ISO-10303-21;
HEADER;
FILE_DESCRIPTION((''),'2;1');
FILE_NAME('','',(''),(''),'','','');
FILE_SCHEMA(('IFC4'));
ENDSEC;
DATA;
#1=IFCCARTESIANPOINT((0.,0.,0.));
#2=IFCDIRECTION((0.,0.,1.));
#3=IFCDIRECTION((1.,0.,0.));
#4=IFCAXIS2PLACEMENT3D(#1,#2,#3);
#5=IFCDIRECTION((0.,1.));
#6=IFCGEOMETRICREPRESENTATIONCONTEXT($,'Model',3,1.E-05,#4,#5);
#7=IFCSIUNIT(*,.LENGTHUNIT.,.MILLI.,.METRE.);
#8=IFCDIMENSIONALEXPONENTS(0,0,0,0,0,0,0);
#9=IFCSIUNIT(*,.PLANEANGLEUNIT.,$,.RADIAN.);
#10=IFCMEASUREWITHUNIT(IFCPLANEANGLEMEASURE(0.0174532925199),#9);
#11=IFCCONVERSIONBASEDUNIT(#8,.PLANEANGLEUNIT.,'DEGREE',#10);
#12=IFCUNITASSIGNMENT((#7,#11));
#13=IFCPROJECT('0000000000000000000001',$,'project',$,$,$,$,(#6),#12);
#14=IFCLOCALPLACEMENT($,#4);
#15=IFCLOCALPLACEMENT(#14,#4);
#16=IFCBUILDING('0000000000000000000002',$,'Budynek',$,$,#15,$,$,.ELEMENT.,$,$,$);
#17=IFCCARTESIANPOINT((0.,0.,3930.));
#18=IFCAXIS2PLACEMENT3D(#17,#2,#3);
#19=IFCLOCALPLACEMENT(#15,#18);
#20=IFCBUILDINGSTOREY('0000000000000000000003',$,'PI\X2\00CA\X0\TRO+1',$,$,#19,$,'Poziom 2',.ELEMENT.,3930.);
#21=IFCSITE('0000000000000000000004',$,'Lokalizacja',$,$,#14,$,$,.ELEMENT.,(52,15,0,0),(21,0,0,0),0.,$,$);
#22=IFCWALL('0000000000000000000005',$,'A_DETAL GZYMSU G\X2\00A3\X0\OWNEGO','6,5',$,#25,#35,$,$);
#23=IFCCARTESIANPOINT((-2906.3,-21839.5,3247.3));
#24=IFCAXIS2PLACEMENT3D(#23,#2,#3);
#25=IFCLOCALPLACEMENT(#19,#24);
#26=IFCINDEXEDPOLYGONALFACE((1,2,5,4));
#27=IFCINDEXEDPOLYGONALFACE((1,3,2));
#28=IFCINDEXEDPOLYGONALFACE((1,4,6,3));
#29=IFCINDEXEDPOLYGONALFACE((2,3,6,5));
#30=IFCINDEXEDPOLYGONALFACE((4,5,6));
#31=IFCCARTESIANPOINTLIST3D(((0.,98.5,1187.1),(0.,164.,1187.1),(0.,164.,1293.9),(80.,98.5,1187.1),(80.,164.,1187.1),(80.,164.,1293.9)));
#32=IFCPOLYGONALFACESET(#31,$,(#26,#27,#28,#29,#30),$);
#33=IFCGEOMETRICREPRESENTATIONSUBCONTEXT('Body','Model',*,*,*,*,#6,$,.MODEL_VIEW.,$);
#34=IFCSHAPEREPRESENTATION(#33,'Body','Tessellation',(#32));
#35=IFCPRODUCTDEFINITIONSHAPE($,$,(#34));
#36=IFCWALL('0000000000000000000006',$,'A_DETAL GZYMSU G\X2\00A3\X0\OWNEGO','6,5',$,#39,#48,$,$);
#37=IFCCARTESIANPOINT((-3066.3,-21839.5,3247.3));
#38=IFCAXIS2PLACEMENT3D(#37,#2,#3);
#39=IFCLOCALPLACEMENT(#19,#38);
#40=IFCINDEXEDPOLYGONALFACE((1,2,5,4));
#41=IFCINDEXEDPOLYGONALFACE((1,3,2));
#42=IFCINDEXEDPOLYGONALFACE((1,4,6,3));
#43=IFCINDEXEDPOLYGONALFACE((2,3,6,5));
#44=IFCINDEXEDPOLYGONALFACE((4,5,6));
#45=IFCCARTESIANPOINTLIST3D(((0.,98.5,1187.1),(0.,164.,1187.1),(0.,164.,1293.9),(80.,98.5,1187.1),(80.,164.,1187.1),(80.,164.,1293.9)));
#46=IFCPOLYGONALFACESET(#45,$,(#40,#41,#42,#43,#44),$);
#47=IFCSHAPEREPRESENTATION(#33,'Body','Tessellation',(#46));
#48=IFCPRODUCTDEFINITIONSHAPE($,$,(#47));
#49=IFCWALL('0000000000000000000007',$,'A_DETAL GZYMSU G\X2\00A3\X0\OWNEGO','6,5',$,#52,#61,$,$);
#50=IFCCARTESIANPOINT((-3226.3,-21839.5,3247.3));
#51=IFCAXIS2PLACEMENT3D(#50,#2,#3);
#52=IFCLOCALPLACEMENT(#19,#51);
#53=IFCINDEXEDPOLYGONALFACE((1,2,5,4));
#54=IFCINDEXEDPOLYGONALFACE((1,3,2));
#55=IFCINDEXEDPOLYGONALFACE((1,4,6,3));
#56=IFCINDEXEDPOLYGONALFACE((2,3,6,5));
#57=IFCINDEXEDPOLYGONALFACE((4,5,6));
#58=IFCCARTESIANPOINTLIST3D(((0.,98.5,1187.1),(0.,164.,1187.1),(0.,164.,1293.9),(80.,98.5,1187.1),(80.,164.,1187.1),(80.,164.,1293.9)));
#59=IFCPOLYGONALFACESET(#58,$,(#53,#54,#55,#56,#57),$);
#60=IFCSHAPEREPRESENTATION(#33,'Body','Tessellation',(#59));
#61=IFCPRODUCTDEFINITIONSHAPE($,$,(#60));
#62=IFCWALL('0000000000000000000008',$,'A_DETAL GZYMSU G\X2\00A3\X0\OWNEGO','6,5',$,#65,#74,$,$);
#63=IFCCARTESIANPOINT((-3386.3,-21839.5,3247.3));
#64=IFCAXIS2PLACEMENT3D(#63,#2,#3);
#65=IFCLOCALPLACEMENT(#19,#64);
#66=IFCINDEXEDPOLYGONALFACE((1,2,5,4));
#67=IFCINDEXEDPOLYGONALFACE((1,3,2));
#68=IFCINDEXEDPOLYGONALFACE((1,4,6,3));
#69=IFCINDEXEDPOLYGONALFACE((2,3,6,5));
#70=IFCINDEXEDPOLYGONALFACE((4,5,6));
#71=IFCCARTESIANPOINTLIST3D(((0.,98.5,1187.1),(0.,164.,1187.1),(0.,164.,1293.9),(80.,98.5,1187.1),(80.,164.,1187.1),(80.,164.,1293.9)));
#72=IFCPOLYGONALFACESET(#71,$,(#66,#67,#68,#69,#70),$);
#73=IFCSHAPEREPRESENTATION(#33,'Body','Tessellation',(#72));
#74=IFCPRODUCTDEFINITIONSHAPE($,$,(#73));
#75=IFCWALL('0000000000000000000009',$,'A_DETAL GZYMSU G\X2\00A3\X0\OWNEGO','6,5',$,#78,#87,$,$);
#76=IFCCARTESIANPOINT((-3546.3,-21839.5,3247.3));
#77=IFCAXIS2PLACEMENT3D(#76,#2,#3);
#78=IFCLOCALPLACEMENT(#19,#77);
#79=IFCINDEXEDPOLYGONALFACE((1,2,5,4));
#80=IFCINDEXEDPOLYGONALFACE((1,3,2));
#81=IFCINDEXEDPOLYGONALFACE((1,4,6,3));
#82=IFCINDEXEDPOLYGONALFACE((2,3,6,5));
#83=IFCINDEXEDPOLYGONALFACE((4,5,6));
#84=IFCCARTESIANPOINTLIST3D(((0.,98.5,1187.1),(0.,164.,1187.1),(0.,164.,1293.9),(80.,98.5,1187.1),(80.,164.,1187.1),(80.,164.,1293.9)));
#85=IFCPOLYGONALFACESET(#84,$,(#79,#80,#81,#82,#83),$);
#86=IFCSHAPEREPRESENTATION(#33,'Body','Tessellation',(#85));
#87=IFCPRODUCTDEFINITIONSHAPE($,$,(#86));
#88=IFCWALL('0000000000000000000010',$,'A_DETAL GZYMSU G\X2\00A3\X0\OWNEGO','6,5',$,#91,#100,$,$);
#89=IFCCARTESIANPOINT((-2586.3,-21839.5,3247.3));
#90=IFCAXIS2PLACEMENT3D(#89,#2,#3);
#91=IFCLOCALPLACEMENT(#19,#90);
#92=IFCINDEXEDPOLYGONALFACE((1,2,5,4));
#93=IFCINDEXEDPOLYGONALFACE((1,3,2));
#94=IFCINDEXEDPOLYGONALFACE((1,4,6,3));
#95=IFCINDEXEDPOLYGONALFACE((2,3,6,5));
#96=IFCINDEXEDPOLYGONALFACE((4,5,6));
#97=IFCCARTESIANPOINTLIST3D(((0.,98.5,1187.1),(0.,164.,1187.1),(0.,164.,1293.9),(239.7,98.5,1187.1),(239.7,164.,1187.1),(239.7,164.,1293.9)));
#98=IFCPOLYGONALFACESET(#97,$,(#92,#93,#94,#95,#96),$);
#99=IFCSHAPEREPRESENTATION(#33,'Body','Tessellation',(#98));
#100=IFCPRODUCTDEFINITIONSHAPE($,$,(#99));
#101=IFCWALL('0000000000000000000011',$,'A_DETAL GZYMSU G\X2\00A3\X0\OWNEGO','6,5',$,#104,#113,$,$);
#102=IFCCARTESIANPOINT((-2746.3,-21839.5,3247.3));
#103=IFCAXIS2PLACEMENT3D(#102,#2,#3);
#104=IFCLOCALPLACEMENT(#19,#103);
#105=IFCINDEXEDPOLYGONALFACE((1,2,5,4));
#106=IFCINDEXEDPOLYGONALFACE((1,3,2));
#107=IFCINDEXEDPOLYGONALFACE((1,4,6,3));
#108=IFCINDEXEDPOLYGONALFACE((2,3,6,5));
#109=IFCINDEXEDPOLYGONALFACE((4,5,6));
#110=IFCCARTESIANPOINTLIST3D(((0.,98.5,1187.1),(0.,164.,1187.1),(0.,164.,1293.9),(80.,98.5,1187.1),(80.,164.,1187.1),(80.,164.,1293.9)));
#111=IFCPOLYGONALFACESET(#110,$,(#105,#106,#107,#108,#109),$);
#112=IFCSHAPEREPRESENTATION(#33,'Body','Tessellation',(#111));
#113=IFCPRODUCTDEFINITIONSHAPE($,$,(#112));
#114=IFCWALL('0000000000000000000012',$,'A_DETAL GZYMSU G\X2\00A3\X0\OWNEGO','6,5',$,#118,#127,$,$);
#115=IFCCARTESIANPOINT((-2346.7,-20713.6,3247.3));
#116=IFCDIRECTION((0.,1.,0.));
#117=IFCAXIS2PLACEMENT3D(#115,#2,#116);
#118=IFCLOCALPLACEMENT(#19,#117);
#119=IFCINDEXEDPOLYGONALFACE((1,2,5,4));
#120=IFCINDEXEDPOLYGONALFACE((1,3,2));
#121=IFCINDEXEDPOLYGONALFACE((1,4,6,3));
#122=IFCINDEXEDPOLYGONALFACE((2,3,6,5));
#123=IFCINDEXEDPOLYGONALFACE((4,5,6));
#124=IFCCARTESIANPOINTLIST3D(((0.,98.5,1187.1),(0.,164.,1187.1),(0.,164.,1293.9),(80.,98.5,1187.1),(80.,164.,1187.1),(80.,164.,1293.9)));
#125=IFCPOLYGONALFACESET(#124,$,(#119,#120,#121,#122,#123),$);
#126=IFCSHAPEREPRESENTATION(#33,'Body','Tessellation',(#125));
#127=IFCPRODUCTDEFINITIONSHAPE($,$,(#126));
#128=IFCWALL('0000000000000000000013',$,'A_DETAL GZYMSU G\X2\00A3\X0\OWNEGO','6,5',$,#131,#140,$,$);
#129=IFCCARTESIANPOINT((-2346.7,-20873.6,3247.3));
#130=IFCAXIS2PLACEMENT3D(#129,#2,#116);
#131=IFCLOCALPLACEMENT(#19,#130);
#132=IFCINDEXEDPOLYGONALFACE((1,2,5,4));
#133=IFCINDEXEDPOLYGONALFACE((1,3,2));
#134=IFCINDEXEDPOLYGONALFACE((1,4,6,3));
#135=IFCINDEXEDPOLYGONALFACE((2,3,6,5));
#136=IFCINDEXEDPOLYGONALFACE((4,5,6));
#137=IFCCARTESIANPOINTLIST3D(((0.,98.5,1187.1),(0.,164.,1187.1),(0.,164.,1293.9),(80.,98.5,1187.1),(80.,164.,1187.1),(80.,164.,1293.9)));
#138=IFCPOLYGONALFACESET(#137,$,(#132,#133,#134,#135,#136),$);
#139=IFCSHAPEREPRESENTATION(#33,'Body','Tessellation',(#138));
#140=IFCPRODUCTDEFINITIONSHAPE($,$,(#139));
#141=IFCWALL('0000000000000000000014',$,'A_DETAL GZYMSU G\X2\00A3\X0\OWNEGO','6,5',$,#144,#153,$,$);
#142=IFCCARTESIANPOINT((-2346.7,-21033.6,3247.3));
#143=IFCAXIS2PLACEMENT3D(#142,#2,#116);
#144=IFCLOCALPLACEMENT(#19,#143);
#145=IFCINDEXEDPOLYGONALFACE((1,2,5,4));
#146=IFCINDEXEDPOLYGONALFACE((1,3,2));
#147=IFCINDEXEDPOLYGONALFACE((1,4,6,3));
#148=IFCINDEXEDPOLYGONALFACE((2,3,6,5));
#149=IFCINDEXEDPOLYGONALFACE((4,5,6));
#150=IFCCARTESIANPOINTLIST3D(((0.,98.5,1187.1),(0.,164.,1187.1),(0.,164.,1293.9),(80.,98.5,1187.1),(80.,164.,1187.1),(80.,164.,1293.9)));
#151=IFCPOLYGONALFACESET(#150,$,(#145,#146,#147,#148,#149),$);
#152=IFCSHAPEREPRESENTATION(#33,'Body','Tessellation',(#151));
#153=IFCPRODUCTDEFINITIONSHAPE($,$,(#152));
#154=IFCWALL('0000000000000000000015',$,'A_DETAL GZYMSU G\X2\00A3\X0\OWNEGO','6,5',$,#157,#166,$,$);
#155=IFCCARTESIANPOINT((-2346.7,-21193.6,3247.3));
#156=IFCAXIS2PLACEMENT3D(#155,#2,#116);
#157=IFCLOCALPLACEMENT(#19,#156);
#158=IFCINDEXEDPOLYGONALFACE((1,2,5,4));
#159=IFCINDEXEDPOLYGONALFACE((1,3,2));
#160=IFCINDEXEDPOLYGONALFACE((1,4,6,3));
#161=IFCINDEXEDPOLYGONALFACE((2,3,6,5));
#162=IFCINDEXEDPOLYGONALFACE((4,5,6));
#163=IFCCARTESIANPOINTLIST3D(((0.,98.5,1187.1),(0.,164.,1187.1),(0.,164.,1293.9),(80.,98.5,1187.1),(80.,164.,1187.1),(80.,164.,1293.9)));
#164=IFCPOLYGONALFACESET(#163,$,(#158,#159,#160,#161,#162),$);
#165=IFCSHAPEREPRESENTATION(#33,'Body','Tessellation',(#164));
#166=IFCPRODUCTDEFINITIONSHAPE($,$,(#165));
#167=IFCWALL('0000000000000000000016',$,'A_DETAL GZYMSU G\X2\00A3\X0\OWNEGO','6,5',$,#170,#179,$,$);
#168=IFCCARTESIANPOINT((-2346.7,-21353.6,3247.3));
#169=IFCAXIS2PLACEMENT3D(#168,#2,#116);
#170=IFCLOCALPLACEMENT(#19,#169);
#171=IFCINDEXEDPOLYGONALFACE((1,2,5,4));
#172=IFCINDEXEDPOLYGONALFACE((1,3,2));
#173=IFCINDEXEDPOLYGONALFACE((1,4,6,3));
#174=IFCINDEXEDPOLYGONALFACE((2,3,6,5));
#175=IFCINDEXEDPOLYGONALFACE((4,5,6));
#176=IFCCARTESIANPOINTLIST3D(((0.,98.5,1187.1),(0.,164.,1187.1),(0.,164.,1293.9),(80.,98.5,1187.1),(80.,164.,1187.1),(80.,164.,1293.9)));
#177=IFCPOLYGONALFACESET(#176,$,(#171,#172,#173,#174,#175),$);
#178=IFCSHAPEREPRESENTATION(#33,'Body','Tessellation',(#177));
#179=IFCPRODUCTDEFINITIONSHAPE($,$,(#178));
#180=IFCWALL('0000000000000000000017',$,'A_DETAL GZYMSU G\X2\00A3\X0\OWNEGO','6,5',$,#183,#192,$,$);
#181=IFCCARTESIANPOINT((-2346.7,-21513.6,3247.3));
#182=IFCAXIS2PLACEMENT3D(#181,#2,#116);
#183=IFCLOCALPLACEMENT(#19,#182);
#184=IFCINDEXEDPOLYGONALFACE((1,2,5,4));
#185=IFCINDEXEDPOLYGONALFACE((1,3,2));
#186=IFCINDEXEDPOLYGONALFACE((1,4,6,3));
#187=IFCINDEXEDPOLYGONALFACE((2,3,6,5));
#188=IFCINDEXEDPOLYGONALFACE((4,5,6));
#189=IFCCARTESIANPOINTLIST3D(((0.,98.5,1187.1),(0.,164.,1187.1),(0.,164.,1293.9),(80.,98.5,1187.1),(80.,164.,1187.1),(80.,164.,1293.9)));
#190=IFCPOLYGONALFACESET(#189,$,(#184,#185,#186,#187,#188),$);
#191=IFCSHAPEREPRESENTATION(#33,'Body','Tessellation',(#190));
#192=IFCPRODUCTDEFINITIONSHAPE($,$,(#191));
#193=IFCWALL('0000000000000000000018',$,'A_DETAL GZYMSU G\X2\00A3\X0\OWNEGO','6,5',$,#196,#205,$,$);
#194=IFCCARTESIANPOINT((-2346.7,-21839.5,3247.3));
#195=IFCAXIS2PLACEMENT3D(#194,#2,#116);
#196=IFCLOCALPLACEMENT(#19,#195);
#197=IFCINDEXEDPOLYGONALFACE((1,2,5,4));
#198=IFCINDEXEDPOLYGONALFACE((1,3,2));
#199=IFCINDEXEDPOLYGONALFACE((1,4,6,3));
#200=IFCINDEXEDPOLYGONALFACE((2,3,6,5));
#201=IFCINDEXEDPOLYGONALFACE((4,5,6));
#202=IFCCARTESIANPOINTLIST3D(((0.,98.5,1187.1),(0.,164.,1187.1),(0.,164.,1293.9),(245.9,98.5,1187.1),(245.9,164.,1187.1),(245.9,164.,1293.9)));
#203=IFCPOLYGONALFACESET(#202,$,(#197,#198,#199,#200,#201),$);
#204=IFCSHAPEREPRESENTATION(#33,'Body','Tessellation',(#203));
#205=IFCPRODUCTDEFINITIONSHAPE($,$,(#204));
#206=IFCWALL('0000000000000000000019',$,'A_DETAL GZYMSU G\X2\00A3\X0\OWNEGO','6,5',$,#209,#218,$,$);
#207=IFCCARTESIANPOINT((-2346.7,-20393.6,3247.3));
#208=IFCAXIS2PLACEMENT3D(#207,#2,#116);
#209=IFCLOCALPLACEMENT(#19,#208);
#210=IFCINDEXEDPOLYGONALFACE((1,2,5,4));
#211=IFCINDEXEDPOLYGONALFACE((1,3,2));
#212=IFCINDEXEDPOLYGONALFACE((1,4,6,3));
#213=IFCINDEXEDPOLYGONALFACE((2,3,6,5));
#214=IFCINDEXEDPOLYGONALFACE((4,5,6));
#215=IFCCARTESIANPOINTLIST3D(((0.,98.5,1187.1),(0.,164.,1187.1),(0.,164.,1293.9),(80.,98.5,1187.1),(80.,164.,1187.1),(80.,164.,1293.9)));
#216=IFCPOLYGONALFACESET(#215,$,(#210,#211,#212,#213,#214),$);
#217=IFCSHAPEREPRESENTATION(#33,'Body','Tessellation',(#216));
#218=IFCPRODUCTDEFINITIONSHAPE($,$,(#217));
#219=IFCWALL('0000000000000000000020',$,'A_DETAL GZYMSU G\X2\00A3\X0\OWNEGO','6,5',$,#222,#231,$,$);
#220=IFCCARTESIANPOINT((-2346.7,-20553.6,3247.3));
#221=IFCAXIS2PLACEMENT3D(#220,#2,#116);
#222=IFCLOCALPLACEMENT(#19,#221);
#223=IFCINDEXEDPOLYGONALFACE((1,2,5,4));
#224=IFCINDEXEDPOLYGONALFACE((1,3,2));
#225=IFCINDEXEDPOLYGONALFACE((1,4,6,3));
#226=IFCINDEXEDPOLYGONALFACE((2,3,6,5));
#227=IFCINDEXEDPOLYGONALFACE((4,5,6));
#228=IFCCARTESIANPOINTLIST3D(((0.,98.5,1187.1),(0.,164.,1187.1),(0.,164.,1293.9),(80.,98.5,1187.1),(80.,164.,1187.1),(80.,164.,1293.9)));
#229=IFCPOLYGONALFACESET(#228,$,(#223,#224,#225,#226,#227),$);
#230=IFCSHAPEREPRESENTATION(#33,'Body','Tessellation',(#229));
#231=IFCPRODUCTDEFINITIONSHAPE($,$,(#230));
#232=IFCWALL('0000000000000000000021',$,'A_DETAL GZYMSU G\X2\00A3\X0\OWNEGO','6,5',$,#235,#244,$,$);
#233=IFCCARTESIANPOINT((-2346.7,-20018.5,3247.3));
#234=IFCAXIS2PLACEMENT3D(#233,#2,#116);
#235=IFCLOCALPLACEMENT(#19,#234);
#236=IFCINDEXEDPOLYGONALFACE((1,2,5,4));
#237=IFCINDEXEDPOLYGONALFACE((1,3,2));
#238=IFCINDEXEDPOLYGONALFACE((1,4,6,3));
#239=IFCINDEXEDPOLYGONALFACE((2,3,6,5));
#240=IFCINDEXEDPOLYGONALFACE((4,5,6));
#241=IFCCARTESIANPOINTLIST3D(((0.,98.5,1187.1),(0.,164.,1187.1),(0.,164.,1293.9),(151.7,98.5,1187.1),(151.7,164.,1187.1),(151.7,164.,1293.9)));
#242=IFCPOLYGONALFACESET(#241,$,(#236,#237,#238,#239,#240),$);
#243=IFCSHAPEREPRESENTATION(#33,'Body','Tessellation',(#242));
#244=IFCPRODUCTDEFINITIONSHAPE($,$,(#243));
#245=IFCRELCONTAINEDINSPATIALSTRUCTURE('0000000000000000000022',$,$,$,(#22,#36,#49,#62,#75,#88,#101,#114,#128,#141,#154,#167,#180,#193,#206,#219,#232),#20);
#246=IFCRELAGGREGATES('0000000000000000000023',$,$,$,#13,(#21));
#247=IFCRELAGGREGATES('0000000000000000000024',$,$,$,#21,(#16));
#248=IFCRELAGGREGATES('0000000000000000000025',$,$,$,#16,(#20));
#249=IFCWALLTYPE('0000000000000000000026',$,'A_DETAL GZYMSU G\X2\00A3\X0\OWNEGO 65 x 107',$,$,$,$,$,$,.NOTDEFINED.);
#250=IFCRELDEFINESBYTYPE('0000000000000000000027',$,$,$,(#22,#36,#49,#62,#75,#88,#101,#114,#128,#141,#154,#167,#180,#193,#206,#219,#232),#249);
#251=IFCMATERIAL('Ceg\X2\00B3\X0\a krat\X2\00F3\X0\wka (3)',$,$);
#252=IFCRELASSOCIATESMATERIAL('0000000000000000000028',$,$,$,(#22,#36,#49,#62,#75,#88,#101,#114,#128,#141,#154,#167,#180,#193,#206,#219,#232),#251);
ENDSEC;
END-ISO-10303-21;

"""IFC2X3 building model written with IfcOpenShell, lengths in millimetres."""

from ifc_helpers import new_model, entity, si_unit, converted_unit, direction, frame, origin_with_axes, place, context, subcontext, project, spatial, polyline, outline, extrude, material, type_object, element, save


model = new_model("IFC2X3")

# Units and contexts
model_context = context("Model", 3, precision=1e-05, world=origin_with_axes(), true_north=direction((0.0, 1.0)))
body_context = subcontext(model_context, "Body", "Model", "MODEL_VIEW")
ifc_project = project(units=[si_unit("LENGTHUNIT", "METRE", prefix="MILLI"), converted_unit("PLANEANGLEUNIT", "DEGREE", entity("IfcPlaneAngleMeasure", 0.0174532925199), si_unit("PLANEANGLEUNIT", "RADIAN"), dimensions=[0, 0, 0, 0, 0, 0, 0])], contexts=[model_context])

# Site, building, storey
site_placement = place(None, origin_with_axes())
site = spatial("IfcSite", under=ifc_project, at=site_placement, Name="Lokalizacja", CompositionType="ELEMENT", RefLatitude=(52, 15, 0, 0), RefLongitude=(21, 0, 0, 0), RefElevation=0.0)
building_placement = place(site_placement, origin_with_axes())
building = spatial("IfcBuilding", under=site, at=building_placement, Name="Budynek", CompositionType="ELEMENT")
storey_placement = place(building_placement, frame((0.0, 0.0, 3930.0), z_axis=(0.0, 0.0, 1.0), x_axis=(1.0, 0.0, 0.0)))
storey = spatial("IfcBuildingStorey", under=building, at=storey_placement, Name="PIÊTRO+1", LongName="Poziom 2", CompositionType="ELEMENT", Elevation=3930.0)

# Shared definitions
ifc_material_1 = material(Name="Ceg³a kratówka (3)")

# Walls
wall_type_1 = type_object("IfcWallType", Name="A_DETAL GZYMSU G£OWNEGO 65 x 107", PredefinedType="NOTDEFINED")
for number, where, z_axis, x_axis, name in (
    (1, (-2906.3, -21839.5, 3247.3), (0.0, 0.0, 1.0), (1.0, 0.0, 0.0), "A_DETAL GZYMSU G£OWNEGO"),
    (2, (-3066.3, -21839.5, 3247.3), (0.0, 0.0, 1.0), (1.0, 0.0, 0.0), "A_DETAL GZYMSU G£OWNEGO"),
    (3, (-3226.3, -21839.5, 3247.3), (0.0, 0.0, 1.0), (1.0, 0.0, 0.0), "A_DETAL GZYMSU G£OWNEGO"),
    (4, (-3386.3, -21839.5, 3247.3), (0.0, 0.0, 1.0), (1.0, 0.0, 0.0), "A_DETAL GZYMSU G£OWNEGO"),
    (5, (-3546.3, -21839.5, 3247.3), (0.0, 0.0, 1.0), (1.0, 0.0, 0.0), "A_DETAL GZYMSU G£OWNEGO"),
):
    element("IfcWall", number, at=place(storey_placement, frame(where, z_axis=z_axis, x_axis=x_axis)), inside=storey, type_object=wall_type_1, material=ifc_material_1, Name=name, Description="6,5", context=body_context, shape_type="SweptSolid", body=[
        extrude(outline(polyline([(-164.0, 1293.9), (-164.0, 1187.1), (-98.5, 1187.1), (-164.0, 1293.9)])), frame((0.0, 0.0, 0.0), z_axis=(-1.0, 0.0, 0.0), x_axis=(0.0, -1.0, 0.0)), (0.0, 0.0, -1.0), 80.0),
    ])
wall_1_placement = place(storey_placement, frame((-2586.3, -21839.5, 3247.3), z_axis=(0.0, 0.0, 1.0), x_axis=(1.0, 0.0, 0.0)))
element("IfcWall", 6, at=wall_1_placement, inside=storey, type_object=wall_type_1, material=ifc_material_1, Name="A_DETAL GZYMSU G£OWNEGO", Description="6,5", context=body_context, shape_type="SweptSolid", body=[
    extrude(outline(polyline([(-164.0, 1293.9), (-164.0, 1187.1), (-98.5, 1187.1), (-164.0, 1293.9)])), frame((0.0, 0.0, 0.0), z_axis=(-1.0, 0.0, 0.0), x_axis=(0.0, -1.0, 0.0)), (0.0, 0.0, -1.0), 239.7),
])
for number, where, z_axis, x_axis, name in (
    (7, (-2746.3, -21839.5, 3247.3), (0.0, 0.0, 1.0), (1.0, 0.0, 0.0), "A_DETAL GZYMSU G£OWNEGO"),
    (8, (-2346.7, -20713.6, 3247.3), (0.0, 0.0, 1.0), (0.0, 1.0, 0.0), "A_DETAL GZYMSU G£OWNEGO"),
    (9, (-2346.7, -20873.6, 3247.3), (0.0, 0.0, 1.0), (0.0, 1.0, 0.0), "A_DETAL GZYMSU G£OWNEGO"),
    (10, (-2346.7, -21033.6, 3247.3), (0.0, 0.0, 1.0), (0.0, 1.0, 0.0), "A_DETAL GZYMSU G£OWNEGO"),
    (11, (-2346.7, -21193.6, 3247.3), (0.0, 0.0, 1.0), (0.0, 1.0, 0.0), "A_DETAL GZYMSU G£OWNEGO"),
    (12, (-2346.7, -21353.6, 3247.3), (0.0, 0.0, 1.0), (0.0, 1.0, 0.0), "A_DETAL GZYMSU G£OWNEGO"),
    (13, (-2346.7, -21513.6, 3247.3), (0.0, 0.0, 1.0), (0.0, 1.0, 0.0), "A_DETAL GZYMSU G£OWNEGO"),
):
    element("IfcWall", number, at=place(storey_placement, frame(where, z_axis=z_axis, x_axis=x_axis)), inside=storey, type_object=wall_type_1, material=ifc_material_1, Name=name, Description="6,5", context=body_context, shape_type="SweptSolid", body=[
        extrude(outline(polyline([(-164.0, 1293.9), (-164.0, 1187.1), (-98.5, 1187.1), (-164.0, 1293.9)])), frame((0.0, 0.0, 0.0), z_axis=(-1.0, 0.0, 0.0), x_axis=(0.0, -1.0, 0.0)), (0.0, 0.0, -1.0), 80.0),
    ])
wall_2_placement = place(storey_placement, frame((-2346.7, -21839.5, 3247.3), z_axis=(0.0, 0.0, 1.0), x_axis=(0.0, 1.0, 0.0)))
element("IfcWall", 14, at=wall_2_placement, inside=storey, type_object=wall_type_1, material=ifc_material_1, Name="A_DETAL GZYMSU G£OWNEGO", Description="6,5", context=body_context, shape_type="SweptSolid", body=[
    extrude(outline(polyline([(-164.0, 1293.9), (-164.0, 1187.1), (-98.5, 1187.1), (-164.0, 1293.9)])), frame((0.0, 0.0, 0.0), z_axis=(-1.0, 0.0, 0.0), x_axis=(0.0, -1.0, 0.0)), (0.0, 0.0, -1.0), 245.9),
])
for number, where, z_axis, x_axis, name in (
    (15, (-2346.7, -20393.6, 3247.3), (0.0, 0.0, 1.0), (0.0, 1.0, 0.0), "A_DETAL GZYMSU G£OWNEGO"),
    (16, (-2346.7, -20553.6, 3247.3), (0.0, 0.0, 1.0), (0.0, 1.0, 0.0), "A_DETAL GZYMSU G£OWNEGO"),
):
    element("IfcWall", number, at=place(storey_placement, frame(where, z_axis=z_axis, x_axis=x_axis)), inside=storey, type_object=wall_type_1, material=ifc_material_1, Name=name, Description="6,5", context=body_context, shape_type="SweptSolid", body=[
        extrude(outline(polyline([(-164.0, 1293.9), (-164.0, 1187.1), (-98.5, 1187.1), (-164.0, 1293.9)])), frame((0.0, 0.0, 0.0), z_axis=(-1.0, 0.0, 0.0), x_axis=(0.0, -1.0, 0.0)), (0.0, 0.0, -1.0), 80.0),
    ])
wall_3_placement = place(storey_placement, frame((-2346.7, -20018.5, 3247.3), z_axis=(0.0, 0.0, 1.0), x_axis=(0.0, 1.0, 0.0)))
element("IfcWall", 17, at=wall_3_placement, inside=storey, type_object=wall_type_1, material=ifc_material_1, Name="A_DETAL GZYMSU G£OWNEGO", Description="6,5", context=body_context, shape_type="SweptSolid", body=[
    extrude(outline(polyline([(-164.0, 1293.9), (-164.0, 1187.1), (-98.5, 1187.1), (-164.0, 1293.9)])), frame((0.0, 0.0, 0.0), z_axis=(-1.0, 0.0, 0.0), x_axis=(0.0, -1.0, 0.0)), (0.0, 0.0, -1.0), 151.7),
])

save(model, "model.ifc")
